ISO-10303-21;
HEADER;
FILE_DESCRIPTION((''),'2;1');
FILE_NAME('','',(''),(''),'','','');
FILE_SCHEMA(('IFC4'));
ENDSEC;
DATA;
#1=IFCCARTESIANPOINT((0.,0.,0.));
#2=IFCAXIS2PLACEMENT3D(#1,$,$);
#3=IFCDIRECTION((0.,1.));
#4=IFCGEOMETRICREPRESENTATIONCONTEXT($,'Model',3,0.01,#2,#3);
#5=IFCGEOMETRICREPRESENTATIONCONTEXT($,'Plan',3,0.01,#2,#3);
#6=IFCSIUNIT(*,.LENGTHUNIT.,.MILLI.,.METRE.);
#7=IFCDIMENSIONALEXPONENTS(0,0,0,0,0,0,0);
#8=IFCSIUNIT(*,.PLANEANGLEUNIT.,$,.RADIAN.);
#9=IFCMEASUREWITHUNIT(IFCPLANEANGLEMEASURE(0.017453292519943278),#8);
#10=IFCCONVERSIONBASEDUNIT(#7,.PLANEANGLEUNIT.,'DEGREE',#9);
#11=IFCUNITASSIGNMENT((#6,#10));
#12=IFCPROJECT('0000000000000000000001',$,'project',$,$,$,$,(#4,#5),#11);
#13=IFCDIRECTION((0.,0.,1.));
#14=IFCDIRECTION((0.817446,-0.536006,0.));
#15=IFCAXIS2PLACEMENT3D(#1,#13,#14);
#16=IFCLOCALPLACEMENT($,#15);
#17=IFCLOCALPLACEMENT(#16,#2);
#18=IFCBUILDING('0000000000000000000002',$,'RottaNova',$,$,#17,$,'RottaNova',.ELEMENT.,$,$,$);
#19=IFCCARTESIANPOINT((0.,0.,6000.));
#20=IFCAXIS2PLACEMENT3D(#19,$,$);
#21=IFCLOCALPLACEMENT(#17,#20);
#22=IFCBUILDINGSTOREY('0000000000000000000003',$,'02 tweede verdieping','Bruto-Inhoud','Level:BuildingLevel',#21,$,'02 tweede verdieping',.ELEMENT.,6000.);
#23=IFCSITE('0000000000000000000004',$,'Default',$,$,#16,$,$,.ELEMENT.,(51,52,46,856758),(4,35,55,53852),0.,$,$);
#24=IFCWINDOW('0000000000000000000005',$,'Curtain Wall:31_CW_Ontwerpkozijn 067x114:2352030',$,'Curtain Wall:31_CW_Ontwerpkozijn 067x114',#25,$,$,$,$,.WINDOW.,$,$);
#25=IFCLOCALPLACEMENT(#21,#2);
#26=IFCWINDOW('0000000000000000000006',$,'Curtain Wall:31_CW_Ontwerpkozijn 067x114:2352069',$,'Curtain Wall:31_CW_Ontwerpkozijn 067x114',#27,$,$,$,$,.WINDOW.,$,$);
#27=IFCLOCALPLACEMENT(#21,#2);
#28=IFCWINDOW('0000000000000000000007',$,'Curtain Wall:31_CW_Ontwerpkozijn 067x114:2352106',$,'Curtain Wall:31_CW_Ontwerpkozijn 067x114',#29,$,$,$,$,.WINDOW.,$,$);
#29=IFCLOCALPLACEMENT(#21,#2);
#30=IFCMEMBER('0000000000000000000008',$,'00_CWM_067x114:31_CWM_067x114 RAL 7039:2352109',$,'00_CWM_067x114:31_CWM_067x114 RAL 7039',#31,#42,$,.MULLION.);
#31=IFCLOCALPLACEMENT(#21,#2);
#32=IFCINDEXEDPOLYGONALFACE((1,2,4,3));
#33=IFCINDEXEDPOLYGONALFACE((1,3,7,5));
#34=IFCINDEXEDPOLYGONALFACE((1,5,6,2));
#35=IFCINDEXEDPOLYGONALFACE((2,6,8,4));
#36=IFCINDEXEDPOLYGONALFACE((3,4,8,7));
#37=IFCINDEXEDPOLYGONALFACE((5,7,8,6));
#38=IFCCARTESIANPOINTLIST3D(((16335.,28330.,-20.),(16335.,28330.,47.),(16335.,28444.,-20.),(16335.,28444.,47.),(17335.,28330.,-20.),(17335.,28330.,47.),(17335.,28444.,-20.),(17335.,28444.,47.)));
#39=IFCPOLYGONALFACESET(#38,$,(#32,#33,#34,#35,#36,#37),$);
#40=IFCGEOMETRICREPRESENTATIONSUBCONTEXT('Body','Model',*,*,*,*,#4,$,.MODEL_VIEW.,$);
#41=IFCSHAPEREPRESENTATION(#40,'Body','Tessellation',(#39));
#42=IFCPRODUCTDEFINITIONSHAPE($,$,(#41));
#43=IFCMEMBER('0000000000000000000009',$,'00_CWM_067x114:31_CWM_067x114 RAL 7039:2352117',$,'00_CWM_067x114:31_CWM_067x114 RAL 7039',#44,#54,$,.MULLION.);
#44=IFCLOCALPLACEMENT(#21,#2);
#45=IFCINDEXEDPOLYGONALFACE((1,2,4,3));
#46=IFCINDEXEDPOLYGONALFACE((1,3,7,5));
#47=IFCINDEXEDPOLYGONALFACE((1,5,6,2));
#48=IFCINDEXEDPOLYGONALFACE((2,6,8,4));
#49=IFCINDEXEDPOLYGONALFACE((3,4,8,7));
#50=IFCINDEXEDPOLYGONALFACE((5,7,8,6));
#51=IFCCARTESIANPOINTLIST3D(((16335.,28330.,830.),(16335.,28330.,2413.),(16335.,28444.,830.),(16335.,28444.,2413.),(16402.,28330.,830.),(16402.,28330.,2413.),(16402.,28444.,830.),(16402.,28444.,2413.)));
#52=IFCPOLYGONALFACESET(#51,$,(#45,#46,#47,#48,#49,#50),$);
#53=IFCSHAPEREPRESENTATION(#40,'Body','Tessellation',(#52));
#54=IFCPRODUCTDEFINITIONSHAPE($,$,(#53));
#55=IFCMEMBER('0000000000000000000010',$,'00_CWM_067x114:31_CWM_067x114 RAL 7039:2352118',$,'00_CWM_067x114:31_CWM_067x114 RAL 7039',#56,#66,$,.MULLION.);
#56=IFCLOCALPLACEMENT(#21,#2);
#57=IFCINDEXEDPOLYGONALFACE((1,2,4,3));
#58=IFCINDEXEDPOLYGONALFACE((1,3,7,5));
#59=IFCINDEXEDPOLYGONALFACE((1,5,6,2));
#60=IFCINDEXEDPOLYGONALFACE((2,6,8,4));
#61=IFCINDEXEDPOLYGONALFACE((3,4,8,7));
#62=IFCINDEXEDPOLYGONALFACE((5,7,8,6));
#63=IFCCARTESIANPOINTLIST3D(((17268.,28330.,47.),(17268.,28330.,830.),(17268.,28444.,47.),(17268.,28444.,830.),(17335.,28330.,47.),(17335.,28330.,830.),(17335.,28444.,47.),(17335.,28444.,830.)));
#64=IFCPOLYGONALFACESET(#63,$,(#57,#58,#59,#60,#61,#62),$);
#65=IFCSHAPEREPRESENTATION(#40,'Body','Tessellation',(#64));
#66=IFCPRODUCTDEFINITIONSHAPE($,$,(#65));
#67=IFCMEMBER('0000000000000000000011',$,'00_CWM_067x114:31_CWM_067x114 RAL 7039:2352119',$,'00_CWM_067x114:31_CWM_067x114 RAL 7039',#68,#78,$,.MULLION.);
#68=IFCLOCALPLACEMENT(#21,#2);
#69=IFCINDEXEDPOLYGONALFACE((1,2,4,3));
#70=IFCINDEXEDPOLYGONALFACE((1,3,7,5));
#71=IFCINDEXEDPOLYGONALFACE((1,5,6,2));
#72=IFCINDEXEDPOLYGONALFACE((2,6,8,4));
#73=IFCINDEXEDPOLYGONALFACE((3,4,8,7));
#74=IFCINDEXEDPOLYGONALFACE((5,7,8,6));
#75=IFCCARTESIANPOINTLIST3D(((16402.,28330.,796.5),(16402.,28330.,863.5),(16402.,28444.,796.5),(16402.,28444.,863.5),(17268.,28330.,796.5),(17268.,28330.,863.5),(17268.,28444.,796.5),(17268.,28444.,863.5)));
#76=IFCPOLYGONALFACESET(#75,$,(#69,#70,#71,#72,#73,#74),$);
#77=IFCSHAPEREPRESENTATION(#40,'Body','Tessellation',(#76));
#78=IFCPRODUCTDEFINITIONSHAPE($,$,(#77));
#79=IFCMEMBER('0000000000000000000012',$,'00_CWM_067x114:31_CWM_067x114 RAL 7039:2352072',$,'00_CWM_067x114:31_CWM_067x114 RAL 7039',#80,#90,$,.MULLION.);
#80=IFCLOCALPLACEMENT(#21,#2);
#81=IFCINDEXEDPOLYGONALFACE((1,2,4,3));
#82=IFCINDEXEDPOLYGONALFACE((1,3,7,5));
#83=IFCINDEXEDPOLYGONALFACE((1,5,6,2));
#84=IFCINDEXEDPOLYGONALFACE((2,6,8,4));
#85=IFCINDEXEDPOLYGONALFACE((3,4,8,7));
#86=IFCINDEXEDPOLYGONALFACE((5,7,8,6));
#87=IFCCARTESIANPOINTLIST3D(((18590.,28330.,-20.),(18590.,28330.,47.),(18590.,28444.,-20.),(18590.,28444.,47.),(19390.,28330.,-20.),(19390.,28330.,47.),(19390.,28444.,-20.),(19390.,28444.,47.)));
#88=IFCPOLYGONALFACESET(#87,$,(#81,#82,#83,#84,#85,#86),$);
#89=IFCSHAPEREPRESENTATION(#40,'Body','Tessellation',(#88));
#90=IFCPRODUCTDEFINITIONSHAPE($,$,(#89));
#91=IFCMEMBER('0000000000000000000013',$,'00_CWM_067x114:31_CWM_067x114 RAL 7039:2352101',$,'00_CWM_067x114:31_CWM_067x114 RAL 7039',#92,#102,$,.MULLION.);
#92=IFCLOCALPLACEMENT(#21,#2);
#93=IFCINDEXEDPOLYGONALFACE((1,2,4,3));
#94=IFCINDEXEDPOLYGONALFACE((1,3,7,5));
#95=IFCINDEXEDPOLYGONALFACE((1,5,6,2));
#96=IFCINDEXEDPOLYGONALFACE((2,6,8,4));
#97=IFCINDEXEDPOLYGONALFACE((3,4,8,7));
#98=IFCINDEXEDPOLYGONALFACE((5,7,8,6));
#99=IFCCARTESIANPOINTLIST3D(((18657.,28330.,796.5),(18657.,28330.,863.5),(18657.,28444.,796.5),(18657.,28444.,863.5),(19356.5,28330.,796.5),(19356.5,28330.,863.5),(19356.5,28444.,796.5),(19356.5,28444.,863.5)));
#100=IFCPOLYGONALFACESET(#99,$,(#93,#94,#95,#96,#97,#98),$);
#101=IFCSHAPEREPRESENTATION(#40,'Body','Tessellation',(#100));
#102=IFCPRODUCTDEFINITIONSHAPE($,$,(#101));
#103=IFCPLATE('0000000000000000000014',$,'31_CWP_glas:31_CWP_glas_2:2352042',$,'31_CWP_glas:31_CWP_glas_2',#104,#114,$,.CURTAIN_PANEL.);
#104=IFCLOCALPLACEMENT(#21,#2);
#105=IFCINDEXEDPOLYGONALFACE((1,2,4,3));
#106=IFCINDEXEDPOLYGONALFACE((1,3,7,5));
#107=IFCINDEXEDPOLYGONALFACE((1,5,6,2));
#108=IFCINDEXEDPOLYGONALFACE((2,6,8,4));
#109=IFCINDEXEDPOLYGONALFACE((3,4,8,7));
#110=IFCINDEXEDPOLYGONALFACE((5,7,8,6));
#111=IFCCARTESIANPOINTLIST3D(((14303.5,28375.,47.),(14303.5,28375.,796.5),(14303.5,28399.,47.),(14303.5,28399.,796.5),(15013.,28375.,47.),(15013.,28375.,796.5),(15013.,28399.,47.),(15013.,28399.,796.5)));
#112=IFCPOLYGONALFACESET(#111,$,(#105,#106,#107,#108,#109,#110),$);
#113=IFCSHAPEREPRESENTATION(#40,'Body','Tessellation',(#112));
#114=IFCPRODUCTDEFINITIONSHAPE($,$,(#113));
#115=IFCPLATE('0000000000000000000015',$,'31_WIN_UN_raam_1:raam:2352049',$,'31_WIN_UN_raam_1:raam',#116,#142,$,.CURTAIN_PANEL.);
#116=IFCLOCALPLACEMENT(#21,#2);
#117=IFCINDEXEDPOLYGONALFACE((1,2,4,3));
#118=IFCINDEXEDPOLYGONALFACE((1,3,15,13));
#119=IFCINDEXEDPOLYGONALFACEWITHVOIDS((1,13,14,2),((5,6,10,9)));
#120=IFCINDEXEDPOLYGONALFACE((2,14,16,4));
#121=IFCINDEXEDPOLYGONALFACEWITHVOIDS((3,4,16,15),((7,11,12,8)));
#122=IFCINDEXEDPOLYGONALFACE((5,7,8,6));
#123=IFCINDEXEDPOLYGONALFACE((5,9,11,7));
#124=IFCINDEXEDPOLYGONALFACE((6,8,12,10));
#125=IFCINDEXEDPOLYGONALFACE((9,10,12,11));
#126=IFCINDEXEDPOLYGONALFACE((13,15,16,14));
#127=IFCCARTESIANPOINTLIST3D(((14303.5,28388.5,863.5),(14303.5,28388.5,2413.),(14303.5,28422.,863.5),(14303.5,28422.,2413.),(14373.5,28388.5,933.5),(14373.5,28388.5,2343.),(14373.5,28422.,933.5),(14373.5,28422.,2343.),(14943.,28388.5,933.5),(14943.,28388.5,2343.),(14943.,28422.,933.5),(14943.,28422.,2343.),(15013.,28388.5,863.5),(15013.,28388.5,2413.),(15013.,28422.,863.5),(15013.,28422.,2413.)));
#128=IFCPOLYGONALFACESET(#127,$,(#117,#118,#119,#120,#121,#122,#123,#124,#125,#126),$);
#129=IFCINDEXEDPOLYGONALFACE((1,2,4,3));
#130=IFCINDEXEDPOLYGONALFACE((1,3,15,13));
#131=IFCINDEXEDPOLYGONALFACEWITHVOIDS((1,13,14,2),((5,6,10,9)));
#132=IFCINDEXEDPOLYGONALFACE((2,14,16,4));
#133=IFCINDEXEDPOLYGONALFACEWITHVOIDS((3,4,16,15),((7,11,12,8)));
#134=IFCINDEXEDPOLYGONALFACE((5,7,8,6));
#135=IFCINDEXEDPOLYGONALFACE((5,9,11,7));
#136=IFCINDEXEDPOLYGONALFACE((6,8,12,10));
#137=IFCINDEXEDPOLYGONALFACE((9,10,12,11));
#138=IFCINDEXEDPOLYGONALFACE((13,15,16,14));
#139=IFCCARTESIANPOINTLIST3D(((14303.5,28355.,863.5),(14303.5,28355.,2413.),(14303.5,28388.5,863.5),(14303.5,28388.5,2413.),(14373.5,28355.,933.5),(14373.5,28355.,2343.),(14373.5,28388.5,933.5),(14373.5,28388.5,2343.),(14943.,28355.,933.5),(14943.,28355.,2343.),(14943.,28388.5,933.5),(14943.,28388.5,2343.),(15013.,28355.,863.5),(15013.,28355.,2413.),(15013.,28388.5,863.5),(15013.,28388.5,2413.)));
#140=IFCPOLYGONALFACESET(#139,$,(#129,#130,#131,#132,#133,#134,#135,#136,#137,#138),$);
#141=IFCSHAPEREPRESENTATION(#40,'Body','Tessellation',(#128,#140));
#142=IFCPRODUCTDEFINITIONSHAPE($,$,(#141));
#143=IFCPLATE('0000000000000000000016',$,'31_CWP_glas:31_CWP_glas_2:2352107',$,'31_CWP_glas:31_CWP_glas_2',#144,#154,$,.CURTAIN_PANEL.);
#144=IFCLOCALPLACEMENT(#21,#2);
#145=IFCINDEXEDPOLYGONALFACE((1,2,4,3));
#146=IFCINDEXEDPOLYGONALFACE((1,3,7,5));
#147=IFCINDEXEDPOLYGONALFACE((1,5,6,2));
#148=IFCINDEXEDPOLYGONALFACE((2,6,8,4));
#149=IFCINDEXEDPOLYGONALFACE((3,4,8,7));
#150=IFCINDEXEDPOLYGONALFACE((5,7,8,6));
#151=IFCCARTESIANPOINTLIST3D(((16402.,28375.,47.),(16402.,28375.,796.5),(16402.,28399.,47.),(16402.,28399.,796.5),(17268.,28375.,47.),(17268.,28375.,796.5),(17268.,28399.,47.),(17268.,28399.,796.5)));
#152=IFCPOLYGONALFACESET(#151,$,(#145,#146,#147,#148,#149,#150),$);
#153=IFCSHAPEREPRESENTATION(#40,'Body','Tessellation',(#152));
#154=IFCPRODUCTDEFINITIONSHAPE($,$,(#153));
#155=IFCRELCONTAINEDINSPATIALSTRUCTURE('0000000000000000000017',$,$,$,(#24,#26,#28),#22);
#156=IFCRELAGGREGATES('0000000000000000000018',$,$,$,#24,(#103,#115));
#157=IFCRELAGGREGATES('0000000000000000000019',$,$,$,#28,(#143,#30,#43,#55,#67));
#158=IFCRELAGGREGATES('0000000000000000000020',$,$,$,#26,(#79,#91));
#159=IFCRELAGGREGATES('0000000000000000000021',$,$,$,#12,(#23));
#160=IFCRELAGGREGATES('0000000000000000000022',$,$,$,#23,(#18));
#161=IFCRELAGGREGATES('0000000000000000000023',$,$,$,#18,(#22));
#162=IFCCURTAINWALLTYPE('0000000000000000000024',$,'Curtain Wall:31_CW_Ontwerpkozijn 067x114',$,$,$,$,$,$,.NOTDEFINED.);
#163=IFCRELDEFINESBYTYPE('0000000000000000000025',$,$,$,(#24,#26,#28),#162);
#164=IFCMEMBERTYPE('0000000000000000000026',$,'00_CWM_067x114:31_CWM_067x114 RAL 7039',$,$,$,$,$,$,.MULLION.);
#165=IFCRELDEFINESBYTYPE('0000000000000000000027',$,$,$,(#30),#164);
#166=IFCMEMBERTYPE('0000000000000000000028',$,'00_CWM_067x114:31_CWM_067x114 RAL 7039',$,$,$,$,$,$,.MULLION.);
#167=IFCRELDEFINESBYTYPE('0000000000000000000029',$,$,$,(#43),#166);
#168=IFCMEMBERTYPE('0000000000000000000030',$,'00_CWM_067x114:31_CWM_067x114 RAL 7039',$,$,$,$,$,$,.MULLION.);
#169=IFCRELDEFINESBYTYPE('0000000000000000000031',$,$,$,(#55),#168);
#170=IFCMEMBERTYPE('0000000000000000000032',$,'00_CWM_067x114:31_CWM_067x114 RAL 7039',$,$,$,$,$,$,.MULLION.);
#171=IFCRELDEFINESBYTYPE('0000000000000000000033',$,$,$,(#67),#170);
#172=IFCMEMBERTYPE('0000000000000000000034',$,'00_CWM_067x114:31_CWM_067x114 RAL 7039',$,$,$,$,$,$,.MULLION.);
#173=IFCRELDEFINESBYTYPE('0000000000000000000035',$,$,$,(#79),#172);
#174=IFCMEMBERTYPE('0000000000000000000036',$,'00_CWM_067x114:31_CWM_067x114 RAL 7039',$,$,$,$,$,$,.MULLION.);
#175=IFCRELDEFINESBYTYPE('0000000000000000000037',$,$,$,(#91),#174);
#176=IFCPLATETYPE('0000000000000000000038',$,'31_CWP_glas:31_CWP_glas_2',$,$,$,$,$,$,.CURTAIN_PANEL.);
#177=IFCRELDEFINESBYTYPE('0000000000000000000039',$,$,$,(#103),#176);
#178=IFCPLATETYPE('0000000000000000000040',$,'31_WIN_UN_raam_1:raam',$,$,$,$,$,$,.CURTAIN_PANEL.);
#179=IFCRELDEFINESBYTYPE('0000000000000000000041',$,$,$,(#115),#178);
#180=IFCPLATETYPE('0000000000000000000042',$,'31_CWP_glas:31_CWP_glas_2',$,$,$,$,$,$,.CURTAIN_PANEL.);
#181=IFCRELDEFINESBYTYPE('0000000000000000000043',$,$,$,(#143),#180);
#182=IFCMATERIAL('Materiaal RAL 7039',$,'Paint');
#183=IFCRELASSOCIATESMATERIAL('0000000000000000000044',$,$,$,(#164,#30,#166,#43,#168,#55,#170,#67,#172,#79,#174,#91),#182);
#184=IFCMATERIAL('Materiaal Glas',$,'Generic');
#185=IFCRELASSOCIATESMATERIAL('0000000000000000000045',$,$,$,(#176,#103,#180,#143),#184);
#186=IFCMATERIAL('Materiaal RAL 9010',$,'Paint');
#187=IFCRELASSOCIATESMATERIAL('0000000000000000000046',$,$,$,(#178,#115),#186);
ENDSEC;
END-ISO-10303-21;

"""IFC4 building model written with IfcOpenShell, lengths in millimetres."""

from ifc_helpers import new_model, entity, si_unit, converted_unit, direction, frame, origin, place, context, subcontext, project, spatial, indexed_curve, outline, extrude, source, transform, mapped, material, type_object, type_shapes, element, aggregate, save


model = new_model("IFC4")

# Units and contexts
model_context = context("Model", 3, precision=0.01, world=origin(), true_north=direction((0.0, 1.0)))
plan_context = context("Plan", 3, precision=0.01, world=origin(), true_north=direction((0.0, 1.0)))
body_context = subcontext(model_context, "Body", "Model", "MODEL_VIEW")
ifc_project = project(units=[si_unit("LENGTHUNIT", "METRE", prefix="MILLI"), converted_unit("PLANEANGLEUNIT", "DEGREE", entity("IfcPlaneAngleMeasure", 0.017453292519943278), si_unit("PLANEANGLEUNIT", "RADIAN"), dimensions=[0, 0, 0, 0, 0, 0, 0])], contexts=[model_context, plan_context])

# Site, building, storey
site_placement = place(None, frame((0.0, 0.0, 0.0), z_axis=(0.0, 0.0, 1.0), x_axis=(0.817446, -0.536006, 0.0)))
site = spatial("IfcSite", under=ifc_project, at=site_placement, Name="Default", CompositionType="ELEMENT", RefLatitude=(51, 52, 46, 856758), RefLongitude=(4, 35, 55, 53852), RefElevation=0.0)
building_placement = place(site_placement, origin())
building = spatial("IfcBuilding", under=site, at=building_placement, Name="RottaNova", LongName="RottaNova", CompositionType="ELEMENT")
storey_placement = place(building_placement, frame((0.0, 0.0, 6000.0)))
storey = spatial("IfcBuildingStorey", under=building, at=storey_placement, Name="02 tweede verdieping", Description="Bruto-Inhoud", ObjectType="Level:BuildingLevel", LongName="02 tweede verdieping", CompositionType="ELEMENT", Elevation=6000.0)

# Window
curtain_wall_type = type_object("IfcCurtainWallType", Name="Curtain Wall:31_CW_Ontwerpkozijn 067x114", PredefinedType="NOTDEFINED")
window_1_placement = place(storey_placement, frame((0.0, 0.0, -6000.0)))
window_1 = element("IfcWindow", 1, at=window_1_placement, inside=storey, type_object=curtain_wall_type, Name="Curtain Wall:31_CW_Ontwerpkozijn 067x114:2352030", ObjectType="Curtain Wall:31_CW_Ontwerpkozijn 067x114", PredefinedType="WINDOW")
ifc_material_1 = material(Name="Materiaal RAL 7039", Category="Paint")

# Window
window_2_placement = place(storey_placement, frame((0.0, 0.0, -6000.0)))
window_2 = element("IfcWindow", 2, at=window_2_placement, inside=storey, type_object=curtain_wall_type, Name="Curtain Wall:31_CW_Ontwerpkozijn 067x114:2352069", ObjectType="Curtain Wall:31_CW_Ontwerpkozijn 067x114", PredefinedType="WINDOW")

# Window, members
window_3_placement = place(storey_placement, frame((0.0, 0.0, -6000.0)))
window_3 = element("IfcWindow", 3, at=window_3_placement, inside=storey, type_object=curtain_wall_type, Name="Curtain Wall:31_CW_Ontwerpkozijn 067x114:2352106", ObjectType="Curtain Wall:31_CW_Ontwerpkozijn 067x114", PredefinedType="WINDOW")
member_type_1 = type_object("IfcMemberType", Name="00_CWM_067x114:31_CWM_067x114 RAL 7039", PredefinedType="MULLION", material=ifc_material_1)
shared_shape_1 = source(origin(), body_context, "Body", "SweptSolid", [
    extrude(outline(indexed_curve([(-33.5, -57.0), (33.5, -57.0), (33.5, 57.0), (-33.5, 57.0), (-33.5, -57.0)], self_intersect=False)), frame((-33.5, 57.0, -1000.0), z_axis=(0.0, 0.0, 1.0), x_axis=(-1.0, 0.0, 0.0)), (0.0, 0.0, 1.0), 1000.0),
])
type_shapes(member_type_1, [shared_shape_1])
member_1_placement = place(window_3_placement, frame((17335.0, 28330.0, 5980.0), z_axis=(1.0, 0.0, 0.0), x_axis=(0.0, 0.0, -1.0)))
member_1 = element("IfcMember", 4, at=member_1_placement, type_object=member_type_1, material=ifc_material_1, Name="00_CWM_067x114:31_CWM_067x114 RAL 7039:2352109", ObjectType="00_CWM_067x114:31_CWM_067x114 RAL 7039", PredefinedType="MULLION", context=body_context, shape_type="MappedRepresentation", body=[
    mapped(shared_shape_1, transform((0.0, 0.0, 0.0), scale=1.0)),
])
member_type_2 = type_object("IfcMemberType", Name="00_CWM_067x114:31_CWM_067x114 RAL 7039", PredefinedType="MULLION", material=ifc_material_1)
shared_shape_2 = source(origin(), body_context, "Body", "SweptSolid", [
    extrude(outline(indexed_curve([(-33.5, -57.0), (33.5, -57.0), (33.5, 57.0), (-33.5, 57.0), (-33.5, -57.0)], self_intersect=False)), frame((-33.5, 57.0, -1583.0), z_axis=(0.0, 0.0, 1.0), x_axis=(-1.0, 0.0, 0.0)), (0.0, 0.0, 1.0), 1583.0),
])
type_shapes(member_type_2, [shared_shape_2])
member_2_placement = place(window_3_placement, frame((16335.0, 28330.0, 6830.0), z_axis=(0.0, 0.0, -1.0), x_axis=(-1.0, 0.0, 0.0)))
member_2 = element("IfcMember", 5, at=member_2_placement, type_object=member_type_2, material=ifc_material_1, Name="00_CWM_067x114:31_CWM_067x114 RAL 7039:2352117", ObjectType="00_CWM_067x114:31_CWM_067x114 RAL 7039", PredefinedType="MULLION", context=body_context, shape_type="MappedRepresentation", body=[
    mapped(shared_shape_2, transform((0.0, 0.0, 0.0), scale=1.0)),
])
member_type_3 = type_object("IfcMemberType", Name="00_CWM_067x114:31_CWM_067x114 RAL 7039", PredefinedType="MULLION", material=ifc_material_1)
shared_shape_3 = source(origin(), body_context, "Body", "SweptSolid", [
    extrude(outline(indexed_curve([(-33.5, -57.0), (33.5, -57.0), (33.5, 57.0), (-33.5, 57.0), (-33.5, -57.0)], self_intersect=False)), frame((-33.5, 57.0, -783.0), z_axis=(0.0, 0.0, 1.0), x_axis=(-1.0, 0.0, 0.0)), (0.0, 0.0, 1.0), 783.0),
])
type_shapes(member_type_3, [shared_shape_3])
member_3_placement = place(window_3_placement, frame((17335.0, 28330.0, 6830.0)))
member_3 = element("IfcMember", 6, at=member_3_placement, type_object=member_type_3, material=ifc_material_1, Name="00_CWM_067x114:31_CWM_067x114 RAL 7039:2352118", ObjectType="00_CWM_067x114:31_CWM_067x114 RAL 7039", PredefinedType="MULLION", context=body_context, shape_type="MappedRepresentation", body=[
    mapped(shared_shape_3, transform((0.0, 0.0, 0.0), scale=1.0)),
])
member_type_4 = type_object("IfcMemberType", Name="00_CWM_067x114:31_CWM_067x114 RAL 7039", PredefinedType="MULLION", material=ifc_material_1)
shared_shape_4 = source(origin(), body_context, "Body", "SweptSolid", [
    extrude(outline(indexed_curve([(-33.5, -57.0), (33.5, -57.0), (33.5, 57.0), (-33.5, 57.0), (-33.5, -57.0)], self_intersect=False)), frame((0.0, 57.0, -866.0), z_axis=(0.0, 0.0, 1.0), x_axis=(-1.0, 0.0, 0.0)), (0.0, 0.0, 1.0), 866.0),
])
type_shapes(member_type_4, [shared_shape_4])
member_4_placement = place(window_3_placement, frame((16402.0, 28330.0, 6830.0), z_axis=(-1.0, 0.0, 0.0), x_axis=(0.0, 0.0, 1.0)))
member_4 = element("IfcMember", 7, at=member_4_placement, type_object=member_type_4, material=ifc_material_1, Name="00_CWM_067x114:31_CWM_067x114 RAL 7039:2352119", ObjectType="00_CWM_067x114:31_CWM_067x114 RAL 7039", PredefinedType="MULLION", context=body_context, shape_type="MappedRepresentation", body=[
    mapped(shared_shape_4, transform((0.0, 0.0, 0.0), scale=1.0)),
])

# Members
member_type_5 = type_object("IfcMemberType", Name="00_CWM_067x114:31_CWM_067x114 RAL 7039", PredefinedType="MULLION", material=ifc_material_1)
shared_shape_5 = source(origin(), body_context, "Body", "SweptSolid", [
    extrude(outline(indexed_curve([(-33.5, -57.0), (33.5, -57.0), (33.5, 57.0), (-33.5, 57.0), (-33.5, -57.0)], self_intersect=False)), frame((-33.5, -57.0, -800.0), z_axis=(0.0, 0.0, 1.0), x_axis=(-1.0, 0.0, 0.0)), (0.0, 0.0, 1.0), 800.0),
])
type_shapes(member_type_5, [shared_shape_5])
member_5_placement = place(window_2_placement, frame((18590.0, 28330.0, 5980.0), z_axis=(-1.0, 0.0, 0.0), x_axis=(0.0, 0.0, -1.0)))
member_5 = element("IfcMember", 8, at=member_5_placement, type_object=member_type_5, material=ifc_material_1, Name="00_CWM_067x114:31_CWM_067x114 RAL 7039:2352072", ObjectType="00_CWM_067x114:31_CWM_067x114 RAL 7039", PredefinedType="MULLION", context=body_context, shape_type="MappedRepresentation", body=[
    mapped(shared_shape_5, transform((0.0, 0.0, 0.0), scale=1.0)),
])
member_type_6 = type_object("IfcMemberType", Name="00_CWM_067x114:31_CWM_067x114 RAL 7039", PredefinedType="MULLION", material=ifc_material_1)
shared_shape_6 = source(origin(), body_context, "Body", "SweptSolid", [
    extrude(outline(indexed_curve([(-33.5, -57.0), (33.5, -57.0), (33.5, 57.0), (-33.5, 57.0), (-33.5, -57.0)], self_intersect=False)), frame((0.0, -57.0, -699.5), z_axis=(0.0, 0.0, 1.0), x_axis=(-1.0, 0.0, 0.0)), (0.0, 0.0, 1.0), 699.5),
])
type_shapes(member_type_6, [shared_shape_6])
member_6_placement = place(window_2_placement, frame((19356.5, 28330.0, 6830.0), z_axis=(1.0, 0.0, 0.0), x_axis=(0.0, 0.0, 1.0)))
member_6 = element("IfcMember", 9, at=member_6_placement, type_object=member_type_6, material=ifc_material_1, Name="00_CWM_067x114:31_CWM_067x114 RAL 7039:2352101", ObjectType="00_CWM_067x114:31_CWM_067x114 RAL 7039", PredefinedType="MULLION", context=body_context, shape_type="MappedRepresentation", body=[
    mapped(shared_shape_6, transform((0.0, 0.0, 0.0), scale=1.0)),
])

# Plates
ifc_material_2 = material(Name="Materiaal Glas", Category="Generic")
plate_type_1 = type_object("IfcPlateType", Name="31_CWP_glas:31_CWP_glas_2", PredefinedType="CURTAIN_PANEL", material=ifc_material_2)
shared_shape_7 = source(origin(), body_context, "Body", "SweptSolid", [
    extrude(outline(indexed_curve([(-12.0, -354.8), (12.0, -354.8), (12.0, 354.8), (-12.0, 354.8), (-12.0, -354.8)], self_intersect=False)), frame((0.0, 57.0, 0.0), z_axis=(0.0, 0.0, 1.0), x_axis=(0.0, 1.0, 0.0)), (0.0, 0.0, 1.0), 749.5),
])
type_shapes(plate_type_1, [shared_shape_7])
plate_1_placement = place(window_1_placement, frame((14658.3, 28330.0, 6047.0)))
plate_1 = element("IfcPlate", 10, at=plate_1_placement, type_object=plate_type_1, material=ifc_material_2, Name="31_CWP_glas:31_CWP_glas_2:2352042", ObjectType="31_CWP_glas:31_CWP_glas_2", PredefinedType="CURTAIN_PANEL", context=body_context, shape_type="MappedRepresentation", body=[
    mapped(shared_shape_7, transform((0.0, 0.0, 0.0), scale=1.0)),
])
ifc_material_3 = material(Name="Materiaal RAL 9010", Category="Paint")
plate_type_2 = type_object("IfcPlateType", Name="31_WIN_UN_raam_1:raam", PredefinedType="CURTAIN_PANEL", material=ifc_material_3)
shared_shape_8 = source(origin(), body_context, "Body", "SweptSolid", [
    extrude(outline(indexed_curve([(-354.8, -774.7), (354.8, -774.7), (354.8, 774.7), (-354.8, 774.7), (-354.8, -774.7)], self_intersect=False), holes=[indexed_curve([(-284.8, 704.7), (284.8, 704.7), (284.8, -704.8), (-284.8, -704.8), (-284.8, 704.7)], self_intersect=False)]), frame((0.0, 58.5, 774.8), z_axis=(0.0, 1.0, 0.0), x_axis=(1.0, 0.0, 0.0)), (0.0, 0.0, 1.0), 33.5),
    extrude(outline(indexed_curve([(-354.8, -774.7), (354.8, -774.7), (354.8, 774.7), (-354.8, 774.7), (-354.8, -774.7)], self_intersect=False), holes=[indexed_curve([(-284.8, 704.7), (284.8, 704.7), (284.8, -704.8), (-284.8, -704.8), (-284.8, 704.7)], self_intersect=False)]), frame((0.0, 25.0, 774.8), z_axis=(0.0, 1.0, 0.0), x_axis=(1.0, 0.0, 0.0)), (0.0, 0.0, 1.0), 33.5),
])
type_shapes(plate_type_2, [shared_shape_8])
plate_2_placement = place(window_1_placement, frame((14658.3, 28330.0, 6863.5)))
plate_2 = element("IfcPlate", 11, at=plate_2_placement, type_object=plate_type_2, material=ifc_material_3, Name="31_WIN_UN_raam_1:raam:2352049", ObjectType="31_WIN_UN_raam_1:raam", PredefinedType="CURTAIN_PANEL", context=body_context, shape_type="MappedRepresentation", body=[
    mapped(shared_shape_8, transform((0.0, 0.0, 0.0), scale=1.0)),
])
aggregate(window_1, [plate_1, plate_2])
plate_type_3 = type_object("IfcPlateType", Name="31_CWP_glas:31_CWP_glas_2", PredefinedType="CURTAIN_PANEL", material=ifc_material_2)
shared_shape_9 = source(origin(), body_context, "Body", "SweptSolid", [
    extrude(outline(indexed_curve([(-12.0, -433.0), (12.0, -433.0), (12.0, 433.0), (-12.0, 433.0), (-12.0, -433.0)], self_intersect=False)), frame((0.0, -57.0, 0.0), z_axis=(0.0, 0.0, 1.0), x_axis=(0.0, 1.0, 0.0)), (0.0, 0.0, 1.0), 749.5),
])
type_shapes(plate_type_3, [shared_shape_9])
plate_3_placement = place(window_3_placement, frame((16835.0, 28330.0, 6047.0), z_axis=(0.0, 0.0, 1.0), x_axis=(-1.0, 0.0, 0.0)))
plate_3 = element("IfcPlate", 12, at=plate_3_placement, type_object=plate_type_3, material=ifc_material_2, Name="31_CWP_glas:31_CWP_glas_2:2352107", ObjectType="31_CWP_glas:31_CWP_glas_2", PredefinedType="CURTAIN_PANEL", context=body_context, shape_type="MappedRepresentation", body=[
    mapped(shared_shape_9, transform((0.0, 0.0, 0.0), scale=1.0)),
])
aggregate(window_3, [plate_3, member_1, member_2, member_3, member_4])
aggregate(window_2, [member_5, member_6])

save(model, "model.ifc")
